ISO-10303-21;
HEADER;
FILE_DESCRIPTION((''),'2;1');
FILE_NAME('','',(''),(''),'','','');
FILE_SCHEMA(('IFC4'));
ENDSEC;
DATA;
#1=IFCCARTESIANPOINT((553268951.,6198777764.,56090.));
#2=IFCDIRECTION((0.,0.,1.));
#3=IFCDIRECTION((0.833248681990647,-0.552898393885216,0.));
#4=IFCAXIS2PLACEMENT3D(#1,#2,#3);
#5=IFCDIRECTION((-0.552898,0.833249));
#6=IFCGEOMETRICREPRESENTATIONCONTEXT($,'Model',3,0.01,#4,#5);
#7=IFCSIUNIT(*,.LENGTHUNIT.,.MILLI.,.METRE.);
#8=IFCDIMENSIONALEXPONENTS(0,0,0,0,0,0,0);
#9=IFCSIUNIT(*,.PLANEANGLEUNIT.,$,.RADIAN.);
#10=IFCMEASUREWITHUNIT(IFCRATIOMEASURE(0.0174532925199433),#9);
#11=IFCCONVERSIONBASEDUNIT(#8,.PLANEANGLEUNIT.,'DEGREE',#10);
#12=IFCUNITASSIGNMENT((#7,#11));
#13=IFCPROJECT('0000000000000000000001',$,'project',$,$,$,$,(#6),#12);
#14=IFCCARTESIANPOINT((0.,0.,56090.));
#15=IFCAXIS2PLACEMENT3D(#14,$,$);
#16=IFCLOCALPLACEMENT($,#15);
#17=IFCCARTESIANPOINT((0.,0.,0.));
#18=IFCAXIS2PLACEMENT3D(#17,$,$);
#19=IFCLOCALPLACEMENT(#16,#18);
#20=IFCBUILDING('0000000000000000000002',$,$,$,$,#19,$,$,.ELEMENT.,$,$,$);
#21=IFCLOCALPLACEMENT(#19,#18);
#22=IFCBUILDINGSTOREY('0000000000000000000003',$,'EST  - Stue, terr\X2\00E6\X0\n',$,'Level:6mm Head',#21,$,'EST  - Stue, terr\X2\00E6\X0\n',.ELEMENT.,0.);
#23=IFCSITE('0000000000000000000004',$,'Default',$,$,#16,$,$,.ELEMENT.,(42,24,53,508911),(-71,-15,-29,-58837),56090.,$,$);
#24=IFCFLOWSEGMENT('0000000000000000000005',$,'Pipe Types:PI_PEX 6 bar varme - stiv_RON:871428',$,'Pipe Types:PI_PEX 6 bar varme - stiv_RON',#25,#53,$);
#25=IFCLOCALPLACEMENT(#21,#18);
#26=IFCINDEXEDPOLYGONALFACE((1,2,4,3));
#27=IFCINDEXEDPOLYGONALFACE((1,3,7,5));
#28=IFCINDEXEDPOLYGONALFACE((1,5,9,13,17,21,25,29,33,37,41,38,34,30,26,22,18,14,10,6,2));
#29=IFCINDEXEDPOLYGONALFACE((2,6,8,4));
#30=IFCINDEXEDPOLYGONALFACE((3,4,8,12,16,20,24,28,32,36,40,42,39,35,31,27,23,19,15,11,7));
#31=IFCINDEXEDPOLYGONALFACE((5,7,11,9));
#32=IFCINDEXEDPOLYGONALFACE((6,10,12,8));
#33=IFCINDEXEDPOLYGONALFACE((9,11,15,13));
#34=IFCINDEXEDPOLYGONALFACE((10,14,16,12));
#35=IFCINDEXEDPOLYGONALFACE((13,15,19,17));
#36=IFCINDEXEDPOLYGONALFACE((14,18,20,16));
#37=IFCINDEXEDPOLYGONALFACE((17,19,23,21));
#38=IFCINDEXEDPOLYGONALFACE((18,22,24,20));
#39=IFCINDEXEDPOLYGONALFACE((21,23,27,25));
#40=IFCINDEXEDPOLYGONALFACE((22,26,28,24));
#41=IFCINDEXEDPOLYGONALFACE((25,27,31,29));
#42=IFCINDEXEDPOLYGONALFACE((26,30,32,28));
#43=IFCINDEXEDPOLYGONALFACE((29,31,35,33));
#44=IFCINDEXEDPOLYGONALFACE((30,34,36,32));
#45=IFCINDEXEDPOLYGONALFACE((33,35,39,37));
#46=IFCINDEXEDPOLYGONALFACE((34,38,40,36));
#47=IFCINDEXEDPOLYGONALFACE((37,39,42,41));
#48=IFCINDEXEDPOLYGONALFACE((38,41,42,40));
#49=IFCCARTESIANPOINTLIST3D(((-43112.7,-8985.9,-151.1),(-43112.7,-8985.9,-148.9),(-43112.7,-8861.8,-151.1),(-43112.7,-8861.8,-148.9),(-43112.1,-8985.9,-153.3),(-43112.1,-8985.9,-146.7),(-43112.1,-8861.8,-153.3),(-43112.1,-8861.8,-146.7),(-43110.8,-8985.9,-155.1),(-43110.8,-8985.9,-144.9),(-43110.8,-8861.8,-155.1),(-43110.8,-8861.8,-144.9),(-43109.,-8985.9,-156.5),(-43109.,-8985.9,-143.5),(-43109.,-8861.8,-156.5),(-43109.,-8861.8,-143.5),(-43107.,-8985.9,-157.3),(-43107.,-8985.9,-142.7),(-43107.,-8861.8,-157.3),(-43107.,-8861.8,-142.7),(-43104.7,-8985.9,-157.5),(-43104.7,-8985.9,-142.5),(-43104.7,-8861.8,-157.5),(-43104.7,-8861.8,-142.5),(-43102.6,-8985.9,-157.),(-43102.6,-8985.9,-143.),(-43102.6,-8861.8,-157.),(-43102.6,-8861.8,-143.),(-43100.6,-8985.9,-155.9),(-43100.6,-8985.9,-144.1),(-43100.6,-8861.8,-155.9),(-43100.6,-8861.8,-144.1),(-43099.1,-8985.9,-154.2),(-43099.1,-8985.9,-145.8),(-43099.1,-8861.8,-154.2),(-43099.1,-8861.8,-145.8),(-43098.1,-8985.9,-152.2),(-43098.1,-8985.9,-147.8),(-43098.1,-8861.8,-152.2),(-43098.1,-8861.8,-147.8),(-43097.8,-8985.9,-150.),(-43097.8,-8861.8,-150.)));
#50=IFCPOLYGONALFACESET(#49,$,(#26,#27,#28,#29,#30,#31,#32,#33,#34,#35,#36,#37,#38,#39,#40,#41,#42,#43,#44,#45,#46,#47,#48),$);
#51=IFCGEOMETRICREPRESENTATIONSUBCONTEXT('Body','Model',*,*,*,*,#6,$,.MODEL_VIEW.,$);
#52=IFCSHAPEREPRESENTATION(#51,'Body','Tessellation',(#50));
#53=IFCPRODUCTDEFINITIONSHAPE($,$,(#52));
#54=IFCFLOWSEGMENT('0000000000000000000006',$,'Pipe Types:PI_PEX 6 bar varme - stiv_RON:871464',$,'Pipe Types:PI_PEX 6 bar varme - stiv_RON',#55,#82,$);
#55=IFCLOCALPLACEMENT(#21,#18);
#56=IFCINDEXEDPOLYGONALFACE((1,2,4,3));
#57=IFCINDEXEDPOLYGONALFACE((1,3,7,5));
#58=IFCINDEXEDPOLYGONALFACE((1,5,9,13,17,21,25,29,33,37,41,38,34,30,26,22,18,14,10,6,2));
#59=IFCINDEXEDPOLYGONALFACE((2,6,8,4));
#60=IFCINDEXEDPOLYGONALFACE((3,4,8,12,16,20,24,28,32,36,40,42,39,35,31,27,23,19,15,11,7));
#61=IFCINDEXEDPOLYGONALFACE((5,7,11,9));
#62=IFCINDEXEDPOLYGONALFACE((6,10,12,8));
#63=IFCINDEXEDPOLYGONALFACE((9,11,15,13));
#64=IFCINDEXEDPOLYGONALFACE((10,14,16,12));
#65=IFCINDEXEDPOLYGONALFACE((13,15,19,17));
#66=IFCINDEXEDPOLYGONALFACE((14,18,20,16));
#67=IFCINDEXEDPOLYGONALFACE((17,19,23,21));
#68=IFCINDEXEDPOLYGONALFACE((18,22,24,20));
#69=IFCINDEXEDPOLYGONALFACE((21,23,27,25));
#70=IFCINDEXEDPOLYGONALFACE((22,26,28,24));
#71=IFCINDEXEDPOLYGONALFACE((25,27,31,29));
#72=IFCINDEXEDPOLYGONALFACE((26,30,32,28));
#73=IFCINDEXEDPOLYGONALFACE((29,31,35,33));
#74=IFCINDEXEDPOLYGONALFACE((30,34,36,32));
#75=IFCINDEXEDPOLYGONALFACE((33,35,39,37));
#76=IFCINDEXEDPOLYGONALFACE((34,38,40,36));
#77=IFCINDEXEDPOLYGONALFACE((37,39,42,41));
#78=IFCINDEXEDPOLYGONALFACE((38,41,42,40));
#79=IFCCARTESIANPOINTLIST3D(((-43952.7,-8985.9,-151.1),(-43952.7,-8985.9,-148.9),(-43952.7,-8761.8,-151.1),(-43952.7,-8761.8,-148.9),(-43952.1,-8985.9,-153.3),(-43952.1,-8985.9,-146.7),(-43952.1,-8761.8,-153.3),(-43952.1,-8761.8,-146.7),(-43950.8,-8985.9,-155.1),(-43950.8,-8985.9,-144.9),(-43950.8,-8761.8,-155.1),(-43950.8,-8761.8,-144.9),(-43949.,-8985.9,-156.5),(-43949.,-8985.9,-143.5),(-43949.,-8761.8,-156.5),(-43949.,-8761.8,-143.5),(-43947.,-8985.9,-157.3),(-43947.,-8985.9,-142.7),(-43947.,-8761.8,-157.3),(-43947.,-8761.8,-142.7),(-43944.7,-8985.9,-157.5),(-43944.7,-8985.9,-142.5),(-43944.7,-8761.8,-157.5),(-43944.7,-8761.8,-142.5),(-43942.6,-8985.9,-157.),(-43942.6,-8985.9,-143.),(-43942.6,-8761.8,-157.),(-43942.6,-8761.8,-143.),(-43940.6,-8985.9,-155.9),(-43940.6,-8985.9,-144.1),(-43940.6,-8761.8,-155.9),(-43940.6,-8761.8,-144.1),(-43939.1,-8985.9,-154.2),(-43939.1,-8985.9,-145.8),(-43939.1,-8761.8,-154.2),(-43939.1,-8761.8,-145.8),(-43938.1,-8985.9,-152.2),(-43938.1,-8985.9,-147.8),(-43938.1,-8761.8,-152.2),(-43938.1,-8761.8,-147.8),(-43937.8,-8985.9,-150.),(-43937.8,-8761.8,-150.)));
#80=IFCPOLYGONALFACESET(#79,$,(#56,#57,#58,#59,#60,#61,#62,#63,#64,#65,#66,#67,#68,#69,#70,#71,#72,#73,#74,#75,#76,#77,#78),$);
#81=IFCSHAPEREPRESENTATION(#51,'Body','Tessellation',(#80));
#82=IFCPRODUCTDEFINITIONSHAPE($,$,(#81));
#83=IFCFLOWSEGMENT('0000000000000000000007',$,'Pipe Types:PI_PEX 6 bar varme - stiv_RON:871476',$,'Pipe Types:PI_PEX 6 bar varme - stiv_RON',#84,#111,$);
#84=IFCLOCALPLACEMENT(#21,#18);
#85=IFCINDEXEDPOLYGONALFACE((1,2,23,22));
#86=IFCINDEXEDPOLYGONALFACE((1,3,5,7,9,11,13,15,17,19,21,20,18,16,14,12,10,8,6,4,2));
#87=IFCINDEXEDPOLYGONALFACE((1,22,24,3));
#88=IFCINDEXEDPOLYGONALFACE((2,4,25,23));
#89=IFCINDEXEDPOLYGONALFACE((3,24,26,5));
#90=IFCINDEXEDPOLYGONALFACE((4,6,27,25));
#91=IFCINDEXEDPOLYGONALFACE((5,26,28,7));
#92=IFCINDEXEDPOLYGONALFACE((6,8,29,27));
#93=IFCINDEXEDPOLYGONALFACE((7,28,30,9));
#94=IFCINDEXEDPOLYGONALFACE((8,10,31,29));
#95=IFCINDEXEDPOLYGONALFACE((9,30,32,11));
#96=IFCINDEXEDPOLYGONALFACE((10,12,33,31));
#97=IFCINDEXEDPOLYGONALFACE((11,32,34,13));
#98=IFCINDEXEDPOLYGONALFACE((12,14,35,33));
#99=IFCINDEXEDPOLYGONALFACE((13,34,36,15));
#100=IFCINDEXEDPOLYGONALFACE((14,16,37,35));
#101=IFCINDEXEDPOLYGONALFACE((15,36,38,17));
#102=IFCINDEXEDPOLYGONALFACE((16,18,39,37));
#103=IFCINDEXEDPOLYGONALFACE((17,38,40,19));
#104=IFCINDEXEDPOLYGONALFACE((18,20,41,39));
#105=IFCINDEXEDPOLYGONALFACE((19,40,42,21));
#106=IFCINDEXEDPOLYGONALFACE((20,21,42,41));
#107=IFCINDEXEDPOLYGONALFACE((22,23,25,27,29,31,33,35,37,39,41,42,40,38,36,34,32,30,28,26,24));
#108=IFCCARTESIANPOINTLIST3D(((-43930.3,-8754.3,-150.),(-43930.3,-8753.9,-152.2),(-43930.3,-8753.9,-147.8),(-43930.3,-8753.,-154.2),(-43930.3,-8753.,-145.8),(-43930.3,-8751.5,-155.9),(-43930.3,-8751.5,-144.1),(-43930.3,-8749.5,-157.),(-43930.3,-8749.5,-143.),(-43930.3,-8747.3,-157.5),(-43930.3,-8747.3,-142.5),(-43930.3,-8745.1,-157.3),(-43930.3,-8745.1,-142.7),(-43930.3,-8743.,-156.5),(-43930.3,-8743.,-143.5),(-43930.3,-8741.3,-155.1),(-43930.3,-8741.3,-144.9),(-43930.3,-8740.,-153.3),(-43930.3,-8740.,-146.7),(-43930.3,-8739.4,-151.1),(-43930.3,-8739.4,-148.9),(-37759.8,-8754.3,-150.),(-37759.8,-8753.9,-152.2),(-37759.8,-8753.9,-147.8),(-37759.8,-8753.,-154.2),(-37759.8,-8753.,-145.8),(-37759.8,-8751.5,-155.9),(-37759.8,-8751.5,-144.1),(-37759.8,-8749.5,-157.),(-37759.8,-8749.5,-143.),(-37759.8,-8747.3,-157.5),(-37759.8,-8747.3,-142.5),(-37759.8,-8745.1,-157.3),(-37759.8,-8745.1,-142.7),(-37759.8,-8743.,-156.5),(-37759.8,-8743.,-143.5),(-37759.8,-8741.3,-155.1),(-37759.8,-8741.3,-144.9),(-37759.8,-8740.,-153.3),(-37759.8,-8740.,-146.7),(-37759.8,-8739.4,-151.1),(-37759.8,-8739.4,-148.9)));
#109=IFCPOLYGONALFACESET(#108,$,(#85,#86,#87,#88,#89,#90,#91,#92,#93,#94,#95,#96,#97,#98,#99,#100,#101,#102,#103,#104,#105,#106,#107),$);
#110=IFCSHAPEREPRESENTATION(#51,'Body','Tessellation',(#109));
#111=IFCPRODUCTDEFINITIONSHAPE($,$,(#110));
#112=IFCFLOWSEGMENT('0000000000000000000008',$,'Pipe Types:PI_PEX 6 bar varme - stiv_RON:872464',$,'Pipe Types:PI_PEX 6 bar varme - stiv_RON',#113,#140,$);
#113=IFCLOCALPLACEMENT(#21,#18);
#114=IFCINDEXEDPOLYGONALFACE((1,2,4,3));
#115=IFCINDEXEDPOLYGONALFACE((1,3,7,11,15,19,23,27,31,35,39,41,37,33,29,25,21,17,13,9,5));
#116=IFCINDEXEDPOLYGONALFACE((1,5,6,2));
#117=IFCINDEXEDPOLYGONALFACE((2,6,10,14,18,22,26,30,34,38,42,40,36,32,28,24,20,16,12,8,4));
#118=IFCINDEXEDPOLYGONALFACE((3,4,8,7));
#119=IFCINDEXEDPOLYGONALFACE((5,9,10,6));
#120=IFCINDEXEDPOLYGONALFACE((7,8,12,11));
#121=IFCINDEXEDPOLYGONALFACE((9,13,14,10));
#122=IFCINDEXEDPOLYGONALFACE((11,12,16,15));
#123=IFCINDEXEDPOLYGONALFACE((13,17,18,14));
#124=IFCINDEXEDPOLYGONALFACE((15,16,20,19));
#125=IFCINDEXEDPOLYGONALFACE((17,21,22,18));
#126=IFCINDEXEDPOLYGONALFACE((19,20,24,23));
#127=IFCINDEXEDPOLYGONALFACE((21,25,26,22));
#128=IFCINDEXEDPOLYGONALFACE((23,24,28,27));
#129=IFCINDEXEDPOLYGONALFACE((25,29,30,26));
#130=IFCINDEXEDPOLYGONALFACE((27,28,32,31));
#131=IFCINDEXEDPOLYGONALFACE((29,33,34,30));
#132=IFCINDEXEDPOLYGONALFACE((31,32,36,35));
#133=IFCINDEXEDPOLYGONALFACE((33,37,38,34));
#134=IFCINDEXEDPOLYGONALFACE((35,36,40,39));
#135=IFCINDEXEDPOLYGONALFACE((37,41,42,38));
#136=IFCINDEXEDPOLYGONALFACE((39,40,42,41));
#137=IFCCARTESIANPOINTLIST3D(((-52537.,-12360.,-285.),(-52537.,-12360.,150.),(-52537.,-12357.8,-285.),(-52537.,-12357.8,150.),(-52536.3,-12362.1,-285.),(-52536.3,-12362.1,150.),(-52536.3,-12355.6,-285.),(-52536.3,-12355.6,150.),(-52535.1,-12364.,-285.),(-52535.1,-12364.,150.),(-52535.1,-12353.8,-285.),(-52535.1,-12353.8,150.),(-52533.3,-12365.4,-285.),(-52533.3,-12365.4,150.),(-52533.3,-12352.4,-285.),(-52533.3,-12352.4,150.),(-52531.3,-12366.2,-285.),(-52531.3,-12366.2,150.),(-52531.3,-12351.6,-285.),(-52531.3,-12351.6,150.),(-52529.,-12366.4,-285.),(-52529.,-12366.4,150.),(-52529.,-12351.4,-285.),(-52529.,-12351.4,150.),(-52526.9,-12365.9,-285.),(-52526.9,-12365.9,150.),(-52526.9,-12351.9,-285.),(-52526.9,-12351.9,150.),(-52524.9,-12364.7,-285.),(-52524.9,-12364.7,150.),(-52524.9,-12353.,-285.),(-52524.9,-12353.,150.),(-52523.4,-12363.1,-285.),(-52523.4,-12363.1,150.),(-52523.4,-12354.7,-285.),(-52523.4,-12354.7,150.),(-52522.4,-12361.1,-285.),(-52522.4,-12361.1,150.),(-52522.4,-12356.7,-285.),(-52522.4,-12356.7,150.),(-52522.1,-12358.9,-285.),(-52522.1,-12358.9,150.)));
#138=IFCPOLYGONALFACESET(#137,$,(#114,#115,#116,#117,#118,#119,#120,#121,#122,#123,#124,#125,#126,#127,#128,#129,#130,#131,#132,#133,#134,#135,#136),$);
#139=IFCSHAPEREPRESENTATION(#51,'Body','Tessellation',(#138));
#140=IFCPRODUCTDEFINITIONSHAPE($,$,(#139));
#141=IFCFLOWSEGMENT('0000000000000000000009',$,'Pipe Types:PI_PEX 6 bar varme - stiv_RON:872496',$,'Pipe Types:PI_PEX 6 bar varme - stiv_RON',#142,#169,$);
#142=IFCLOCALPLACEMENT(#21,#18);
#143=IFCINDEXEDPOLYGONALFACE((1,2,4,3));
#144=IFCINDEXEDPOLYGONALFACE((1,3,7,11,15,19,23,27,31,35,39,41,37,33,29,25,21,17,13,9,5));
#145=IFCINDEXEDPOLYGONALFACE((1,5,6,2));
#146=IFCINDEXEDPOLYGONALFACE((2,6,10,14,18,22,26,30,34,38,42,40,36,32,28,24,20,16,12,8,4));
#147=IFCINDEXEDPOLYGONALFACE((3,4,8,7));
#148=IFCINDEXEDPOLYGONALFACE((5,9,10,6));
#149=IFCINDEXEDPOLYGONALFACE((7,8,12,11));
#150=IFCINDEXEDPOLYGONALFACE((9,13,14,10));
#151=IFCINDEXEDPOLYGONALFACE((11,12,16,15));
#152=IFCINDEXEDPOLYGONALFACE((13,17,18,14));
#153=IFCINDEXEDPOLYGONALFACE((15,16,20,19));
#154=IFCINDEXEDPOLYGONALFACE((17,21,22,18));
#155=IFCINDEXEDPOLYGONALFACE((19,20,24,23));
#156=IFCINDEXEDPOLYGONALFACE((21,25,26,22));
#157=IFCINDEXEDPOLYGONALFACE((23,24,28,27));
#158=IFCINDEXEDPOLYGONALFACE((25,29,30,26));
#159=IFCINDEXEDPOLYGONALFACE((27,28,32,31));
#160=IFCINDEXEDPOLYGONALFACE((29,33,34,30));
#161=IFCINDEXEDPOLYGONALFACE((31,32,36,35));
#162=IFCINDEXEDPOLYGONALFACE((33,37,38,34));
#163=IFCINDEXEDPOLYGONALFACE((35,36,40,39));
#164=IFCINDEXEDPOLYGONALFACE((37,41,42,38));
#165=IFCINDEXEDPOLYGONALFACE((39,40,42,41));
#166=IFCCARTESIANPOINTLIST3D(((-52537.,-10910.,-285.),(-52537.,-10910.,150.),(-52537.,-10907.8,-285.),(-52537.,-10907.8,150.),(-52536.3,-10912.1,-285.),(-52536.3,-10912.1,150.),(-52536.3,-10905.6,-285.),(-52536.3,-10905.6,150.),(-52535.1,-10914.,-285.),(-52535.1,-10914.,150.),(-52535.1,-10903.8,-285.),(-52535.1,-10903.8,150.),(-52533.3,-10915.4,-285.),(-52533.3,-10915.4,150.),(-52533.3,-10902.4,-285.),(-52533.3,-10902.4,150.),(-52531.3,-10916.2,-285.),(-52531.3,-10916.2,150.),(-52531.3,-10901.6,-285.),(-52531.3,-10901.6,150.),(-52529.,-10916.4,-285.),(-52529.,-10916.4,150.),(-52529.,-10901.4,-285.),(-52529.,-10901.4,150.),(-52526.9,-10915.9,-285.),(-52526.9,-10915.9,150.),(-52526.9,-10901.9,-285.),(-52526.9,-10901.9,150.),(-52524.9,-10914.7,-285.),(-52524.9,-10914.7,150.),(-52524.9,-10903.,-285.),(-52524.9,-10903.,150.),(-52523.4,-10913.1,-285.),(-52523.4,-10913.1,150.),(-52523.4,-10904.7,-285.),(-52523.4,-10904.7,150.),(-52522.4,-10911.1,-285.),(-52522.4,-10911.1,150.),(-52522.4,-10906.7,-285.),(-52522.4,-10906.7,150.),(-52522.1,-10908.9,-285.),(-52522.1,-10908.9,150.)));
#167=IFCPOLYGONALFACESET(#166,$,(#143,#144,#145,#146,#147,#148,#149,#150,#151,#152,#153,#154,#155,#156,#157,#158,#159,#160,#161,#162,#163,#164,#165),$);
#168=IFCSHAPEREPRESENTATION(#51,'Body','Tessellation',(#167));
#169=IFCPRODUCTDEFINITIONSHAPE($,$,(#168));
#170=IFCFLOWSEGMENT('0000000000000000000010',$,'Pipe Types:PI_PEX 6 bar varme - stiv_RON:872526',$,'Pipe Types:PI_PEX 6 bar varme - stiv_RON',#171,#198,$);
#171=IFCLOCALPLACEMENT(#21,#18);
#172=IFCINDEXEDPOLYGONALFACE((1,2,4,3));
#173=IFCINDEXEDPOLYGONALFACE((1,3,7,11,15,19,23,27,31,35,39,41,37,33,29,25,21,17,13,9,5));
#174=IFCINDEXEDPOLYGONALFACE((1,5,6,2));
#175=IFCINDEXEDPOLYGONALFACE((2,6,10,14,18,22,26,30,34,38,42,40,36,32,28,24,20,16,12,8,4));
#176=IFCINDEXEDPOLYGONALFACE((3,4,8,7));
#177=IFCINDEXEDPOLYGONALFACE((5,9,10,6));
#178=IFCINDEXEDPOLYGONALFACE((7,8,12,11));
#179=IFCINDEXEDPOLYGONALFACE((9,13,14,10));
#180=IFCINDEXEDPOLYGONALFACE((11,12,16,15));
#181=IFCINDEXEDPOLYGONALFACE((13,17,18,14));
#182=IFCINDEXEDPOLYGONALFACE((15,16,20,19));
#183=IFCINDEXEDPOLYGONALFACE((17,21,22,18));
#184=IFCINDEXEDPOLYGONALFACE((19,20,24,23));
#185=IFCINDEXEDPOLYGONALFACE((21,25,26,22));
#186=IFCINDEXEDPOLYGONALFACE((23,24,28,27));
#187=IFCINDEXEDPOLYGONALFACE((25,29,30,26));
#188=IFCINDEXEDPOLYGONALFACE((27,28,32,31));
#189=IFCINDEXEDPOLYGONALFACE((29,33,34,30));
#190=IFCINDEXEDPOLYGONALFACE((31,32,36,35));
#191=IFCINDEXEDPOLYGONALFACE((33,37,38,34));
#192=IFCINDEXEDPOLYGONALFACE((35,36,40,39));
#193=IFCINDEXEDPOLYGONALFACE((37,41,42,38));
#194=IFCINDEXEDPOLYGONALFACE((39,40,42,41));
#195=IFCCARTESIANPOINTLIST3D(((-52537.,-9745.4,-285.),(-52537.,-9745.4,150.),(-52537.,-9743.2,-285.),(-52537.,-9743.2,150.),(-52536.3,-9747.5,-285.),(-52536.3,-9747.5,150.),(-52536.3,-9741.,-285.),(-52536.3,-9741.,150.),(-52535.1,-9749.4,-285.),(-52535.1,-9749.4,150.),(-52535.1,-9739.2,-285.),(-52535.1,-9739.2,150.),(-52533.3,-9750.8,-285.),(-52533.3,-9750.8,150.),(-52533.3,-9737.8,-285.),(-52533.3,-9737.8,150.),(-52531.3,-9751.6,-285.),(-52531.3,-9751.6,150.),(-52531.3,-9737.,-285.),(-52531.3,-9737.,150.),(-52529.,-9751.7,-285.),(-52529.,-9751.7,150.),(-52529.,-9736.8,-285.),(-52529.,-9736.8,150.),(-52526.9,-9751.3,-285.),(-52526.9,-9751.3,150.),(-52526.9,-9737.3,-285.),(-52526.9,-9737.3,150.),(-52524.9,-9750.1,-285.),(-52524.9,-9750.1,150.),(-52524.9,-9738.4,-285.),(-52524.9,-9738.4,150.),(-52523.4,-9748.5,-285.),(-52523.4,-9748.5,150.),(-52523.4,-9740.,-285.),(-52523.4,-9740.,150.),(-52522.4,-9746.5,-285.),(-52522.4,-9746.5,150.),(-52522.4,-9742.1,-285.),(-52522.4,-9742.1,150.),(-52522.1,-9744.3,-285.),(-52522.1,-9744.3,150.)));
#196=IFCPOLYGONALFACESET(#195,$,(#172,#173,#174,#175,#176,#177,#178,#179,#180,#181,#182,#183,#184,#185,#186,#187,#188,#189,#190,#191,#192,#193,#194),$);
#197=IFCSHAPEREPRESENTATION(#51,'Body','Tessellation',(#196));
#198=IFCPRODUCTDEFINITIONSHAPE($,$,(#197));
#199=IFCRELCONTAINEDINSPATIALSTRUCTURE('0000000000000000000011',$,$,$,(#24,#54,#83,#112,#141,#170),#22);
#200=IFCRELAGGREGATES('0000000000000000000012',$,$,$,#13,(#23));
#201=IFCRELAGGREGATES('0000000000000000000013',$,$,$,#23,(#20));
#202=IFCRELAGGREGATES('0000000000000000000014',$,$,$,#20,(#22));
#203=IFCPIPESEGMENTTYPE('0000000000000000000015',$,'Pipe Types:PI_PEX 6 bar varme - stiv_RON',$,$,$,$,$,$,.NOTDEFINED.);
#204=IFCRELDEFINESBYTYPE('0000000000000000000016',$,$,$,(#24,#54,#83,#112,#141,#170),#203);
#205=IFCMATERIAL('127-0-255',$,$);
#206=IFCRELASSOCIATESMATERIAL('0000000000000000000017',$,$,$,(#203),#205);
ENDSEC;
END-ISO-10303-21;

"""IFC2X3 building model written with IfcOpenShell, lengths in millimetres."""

from ifc_helpers import new_model, entity, si_unit, converted_unit, direction, frame, origin, origin_2d_with_axis, place, context, subcontext, project, spatial, circle, extrude, material, type_object, element, save


model = new_model("IFC2X3")

# Units and contexts
model_context = context("Model", 3, precision=0.01, world=frame((553268951.0, 6198777764.0, 56090.0), z_axis=(0.0, 0.0, 1.0), x_axis=(0.833248681990647, -0.552898393885216, 0.0)), true_north=direction((-0.552898, 0.833249)))
body_context = subcontext(model_context, "Body", "Model", "MODEL_VIEW")
ifc_project = project(units=[si_unit("LENGTHUNIT", "METRE", prefix="MILLI"), converted_unit("PLANEANGLEUNIT", "DEGREE", entity("IfcRatioMeasure", 0.0174532925199433), si_unit("PLANEANGLEUNIT", "RADIAN"), dimensions=[0, 0, 0, 0, 0, 0, 0])], contexts=[model_context])

# Site, building, storey
site_placement = place(None, frame((0.0, 0.0, 56090.0)))
site = spatial("IfcSite", under=ifc_project, at=site_placement, Name="Default", CompositionType="ELEMENT", RefLatitude=(42, 24, 53, 508911), RefLongitude=(-71, -15, -29, -58837), RefElevation=56090.0)
building_placement = place(site_placement, origin())
building = spatial("IfcBuilding", under=site, at=building_placement, CompositionType="ELEMENT")
storey_placement = place(building_placement, frame((0.0, 0.0, 0.0)))
storey = spatial("IfcBuildingStorey", under=building, at=storey_placement, Name="EST  - Stue, terræn", ObjectType="Level:6mm Head", LongName="EST  - Stue, terræn", CompositionType="ELEMENT", Elevation=0.0)

# Flow segments
ifc_material = material(Name="127-0-255")
pipe_segment_type = type_object("IfcPipeSegmentType", Name="Pipe Types:PI_PEX 6 bar varme - stiv_RON", PredefinedType="NOTDEFINED", material=ifc_material)
flow_segment_1_placement = place(storey_placement, origin())
element("IfcFlowSegment", 1, at=flow_segment_1_placement, inside=storey, type_object=pipe_segment_type, Name="Pipe Types:PI_PEX 6 bar varme - stiv_RON:871428", ObjectType="Pipe Types:PI_PEX 6 bar varme - stiv_RON", context=body_context, shape_type="SweptSolid", body=[
    extrude(circle(Radius=7.5, at=origin_2d_with_axis()), frame((-43105.3, -8985.9, -150.0), z_axis=(0.0, 1.0, 0.0), x_axis=(1.0, 0.0, 0.0)), (0.0, 0.0, 1.0), 124.1),
])
flow_segment_2_placement = place(storey_placement, origin())
element("IfcFlowSegment", 2, at=flow_segment_2_placement, inside=storey, type_object=pipe_segment_type, Name="Pipe Types:PI_PEX 6 bar varme - stiv_RON:871464", ObjectType="Pipe Types:PI_PEX 6 bar varme - stiv_RON", context=body_context, shape_type="SweptSolid", body=[
    extrude(circle(Radius=7.5, at=origin_2d_with_axis()), frame((-43945.3, -8985.9, -150.0), z_axis=(0.0, 1.0, 0.0), x_axis=(1.0, 0.0, 0.0)), (0.0, 0.0, 1.0), 224.1),
])
flow_segment_3_placement = place(storey_placement, origin())
element("IfcFlowSegment", 3, at=flow_segment_3_placement, inside=storey, type_object=pipe_segment_type, Name="Pipe Types:PI_PEX 6 bar varme - stiv_RON:871476", ObjectType="Pipe Types:PI_PEX 6 bar varme - stiv_RON", context=body_context, shape_type="SweptSolid", body=[
    extrude(circle(Radius=7.5, at=origin_2d_with_axis()), frame((-43930.3, -8746.8, -150.0), z_axis=(1.0, 0.0, 0.0), x_axis=(0.0, -1.0, 0.0)), (0.0, 0.0, 1.0), 6170.5),
])
flow_segment_4_placement = place(storey_placement, origin())
element("IfcFlowSegment", 4, at=flow_segment_4_placement, inside=storey, type_object=pipe_segment_type, Name="Pipe Types:PI_PEX 6 bar varme - stiv_RON:872464", ObjectType="Pipe Types:PI_PEX 6 bar varme - stiv_RON", context=body_context, shape_type="SweptSolid", body=[
    extrude(circle(Radius=7.5, at=origin_2d_with_axis()), frame((-52529.6, -12358.9, -285.0)), (0.0, 0.0, 1.0), 435.0),
])
flow_segment_5_placement = place(storey_placement, origin())
element("IfcFlowSegment", 5, at=flow_segment_5_placement, inside=storey, type_object=pipe_segment_type, Name="Pipe Types:PI_PEX 6 bar varme - stiv_RON:872496", ObjectType="Pipe Types:PI_PEX 6 bar varme - stiv_RON", context=body_context, shape_type="SweptSolid", body=[
    extrude(circle(Radius=7.5, at=origin_2d_with_axis()), frame((-52529.6, -10908.9, -285.0)), (0.0, 0.0, 1.0), 435.0),
])
flow_segment_6_placement = place(storey_placement, origin())
element("IfcFlowSegment", 6, at=flow_segment_6_placement, inside=storey, type_object=pipe_segment_type, Name="Pipe Types:PI_PEX 6 bar varme - stiv_RON:872526", ObjectType="Pipe Types:PI_PEX 6 bar varme - stiv_RON", context=body_context, shape_type="SweptSolid", body=[
    extrude(circle(Radius=7.5, at=origin_2d_with_axis()), frame((-52529.6, -9744.3, -285.0)), (0.0, 0.0, 1.0), 435.0),
])

save(model, "model.ifc")
